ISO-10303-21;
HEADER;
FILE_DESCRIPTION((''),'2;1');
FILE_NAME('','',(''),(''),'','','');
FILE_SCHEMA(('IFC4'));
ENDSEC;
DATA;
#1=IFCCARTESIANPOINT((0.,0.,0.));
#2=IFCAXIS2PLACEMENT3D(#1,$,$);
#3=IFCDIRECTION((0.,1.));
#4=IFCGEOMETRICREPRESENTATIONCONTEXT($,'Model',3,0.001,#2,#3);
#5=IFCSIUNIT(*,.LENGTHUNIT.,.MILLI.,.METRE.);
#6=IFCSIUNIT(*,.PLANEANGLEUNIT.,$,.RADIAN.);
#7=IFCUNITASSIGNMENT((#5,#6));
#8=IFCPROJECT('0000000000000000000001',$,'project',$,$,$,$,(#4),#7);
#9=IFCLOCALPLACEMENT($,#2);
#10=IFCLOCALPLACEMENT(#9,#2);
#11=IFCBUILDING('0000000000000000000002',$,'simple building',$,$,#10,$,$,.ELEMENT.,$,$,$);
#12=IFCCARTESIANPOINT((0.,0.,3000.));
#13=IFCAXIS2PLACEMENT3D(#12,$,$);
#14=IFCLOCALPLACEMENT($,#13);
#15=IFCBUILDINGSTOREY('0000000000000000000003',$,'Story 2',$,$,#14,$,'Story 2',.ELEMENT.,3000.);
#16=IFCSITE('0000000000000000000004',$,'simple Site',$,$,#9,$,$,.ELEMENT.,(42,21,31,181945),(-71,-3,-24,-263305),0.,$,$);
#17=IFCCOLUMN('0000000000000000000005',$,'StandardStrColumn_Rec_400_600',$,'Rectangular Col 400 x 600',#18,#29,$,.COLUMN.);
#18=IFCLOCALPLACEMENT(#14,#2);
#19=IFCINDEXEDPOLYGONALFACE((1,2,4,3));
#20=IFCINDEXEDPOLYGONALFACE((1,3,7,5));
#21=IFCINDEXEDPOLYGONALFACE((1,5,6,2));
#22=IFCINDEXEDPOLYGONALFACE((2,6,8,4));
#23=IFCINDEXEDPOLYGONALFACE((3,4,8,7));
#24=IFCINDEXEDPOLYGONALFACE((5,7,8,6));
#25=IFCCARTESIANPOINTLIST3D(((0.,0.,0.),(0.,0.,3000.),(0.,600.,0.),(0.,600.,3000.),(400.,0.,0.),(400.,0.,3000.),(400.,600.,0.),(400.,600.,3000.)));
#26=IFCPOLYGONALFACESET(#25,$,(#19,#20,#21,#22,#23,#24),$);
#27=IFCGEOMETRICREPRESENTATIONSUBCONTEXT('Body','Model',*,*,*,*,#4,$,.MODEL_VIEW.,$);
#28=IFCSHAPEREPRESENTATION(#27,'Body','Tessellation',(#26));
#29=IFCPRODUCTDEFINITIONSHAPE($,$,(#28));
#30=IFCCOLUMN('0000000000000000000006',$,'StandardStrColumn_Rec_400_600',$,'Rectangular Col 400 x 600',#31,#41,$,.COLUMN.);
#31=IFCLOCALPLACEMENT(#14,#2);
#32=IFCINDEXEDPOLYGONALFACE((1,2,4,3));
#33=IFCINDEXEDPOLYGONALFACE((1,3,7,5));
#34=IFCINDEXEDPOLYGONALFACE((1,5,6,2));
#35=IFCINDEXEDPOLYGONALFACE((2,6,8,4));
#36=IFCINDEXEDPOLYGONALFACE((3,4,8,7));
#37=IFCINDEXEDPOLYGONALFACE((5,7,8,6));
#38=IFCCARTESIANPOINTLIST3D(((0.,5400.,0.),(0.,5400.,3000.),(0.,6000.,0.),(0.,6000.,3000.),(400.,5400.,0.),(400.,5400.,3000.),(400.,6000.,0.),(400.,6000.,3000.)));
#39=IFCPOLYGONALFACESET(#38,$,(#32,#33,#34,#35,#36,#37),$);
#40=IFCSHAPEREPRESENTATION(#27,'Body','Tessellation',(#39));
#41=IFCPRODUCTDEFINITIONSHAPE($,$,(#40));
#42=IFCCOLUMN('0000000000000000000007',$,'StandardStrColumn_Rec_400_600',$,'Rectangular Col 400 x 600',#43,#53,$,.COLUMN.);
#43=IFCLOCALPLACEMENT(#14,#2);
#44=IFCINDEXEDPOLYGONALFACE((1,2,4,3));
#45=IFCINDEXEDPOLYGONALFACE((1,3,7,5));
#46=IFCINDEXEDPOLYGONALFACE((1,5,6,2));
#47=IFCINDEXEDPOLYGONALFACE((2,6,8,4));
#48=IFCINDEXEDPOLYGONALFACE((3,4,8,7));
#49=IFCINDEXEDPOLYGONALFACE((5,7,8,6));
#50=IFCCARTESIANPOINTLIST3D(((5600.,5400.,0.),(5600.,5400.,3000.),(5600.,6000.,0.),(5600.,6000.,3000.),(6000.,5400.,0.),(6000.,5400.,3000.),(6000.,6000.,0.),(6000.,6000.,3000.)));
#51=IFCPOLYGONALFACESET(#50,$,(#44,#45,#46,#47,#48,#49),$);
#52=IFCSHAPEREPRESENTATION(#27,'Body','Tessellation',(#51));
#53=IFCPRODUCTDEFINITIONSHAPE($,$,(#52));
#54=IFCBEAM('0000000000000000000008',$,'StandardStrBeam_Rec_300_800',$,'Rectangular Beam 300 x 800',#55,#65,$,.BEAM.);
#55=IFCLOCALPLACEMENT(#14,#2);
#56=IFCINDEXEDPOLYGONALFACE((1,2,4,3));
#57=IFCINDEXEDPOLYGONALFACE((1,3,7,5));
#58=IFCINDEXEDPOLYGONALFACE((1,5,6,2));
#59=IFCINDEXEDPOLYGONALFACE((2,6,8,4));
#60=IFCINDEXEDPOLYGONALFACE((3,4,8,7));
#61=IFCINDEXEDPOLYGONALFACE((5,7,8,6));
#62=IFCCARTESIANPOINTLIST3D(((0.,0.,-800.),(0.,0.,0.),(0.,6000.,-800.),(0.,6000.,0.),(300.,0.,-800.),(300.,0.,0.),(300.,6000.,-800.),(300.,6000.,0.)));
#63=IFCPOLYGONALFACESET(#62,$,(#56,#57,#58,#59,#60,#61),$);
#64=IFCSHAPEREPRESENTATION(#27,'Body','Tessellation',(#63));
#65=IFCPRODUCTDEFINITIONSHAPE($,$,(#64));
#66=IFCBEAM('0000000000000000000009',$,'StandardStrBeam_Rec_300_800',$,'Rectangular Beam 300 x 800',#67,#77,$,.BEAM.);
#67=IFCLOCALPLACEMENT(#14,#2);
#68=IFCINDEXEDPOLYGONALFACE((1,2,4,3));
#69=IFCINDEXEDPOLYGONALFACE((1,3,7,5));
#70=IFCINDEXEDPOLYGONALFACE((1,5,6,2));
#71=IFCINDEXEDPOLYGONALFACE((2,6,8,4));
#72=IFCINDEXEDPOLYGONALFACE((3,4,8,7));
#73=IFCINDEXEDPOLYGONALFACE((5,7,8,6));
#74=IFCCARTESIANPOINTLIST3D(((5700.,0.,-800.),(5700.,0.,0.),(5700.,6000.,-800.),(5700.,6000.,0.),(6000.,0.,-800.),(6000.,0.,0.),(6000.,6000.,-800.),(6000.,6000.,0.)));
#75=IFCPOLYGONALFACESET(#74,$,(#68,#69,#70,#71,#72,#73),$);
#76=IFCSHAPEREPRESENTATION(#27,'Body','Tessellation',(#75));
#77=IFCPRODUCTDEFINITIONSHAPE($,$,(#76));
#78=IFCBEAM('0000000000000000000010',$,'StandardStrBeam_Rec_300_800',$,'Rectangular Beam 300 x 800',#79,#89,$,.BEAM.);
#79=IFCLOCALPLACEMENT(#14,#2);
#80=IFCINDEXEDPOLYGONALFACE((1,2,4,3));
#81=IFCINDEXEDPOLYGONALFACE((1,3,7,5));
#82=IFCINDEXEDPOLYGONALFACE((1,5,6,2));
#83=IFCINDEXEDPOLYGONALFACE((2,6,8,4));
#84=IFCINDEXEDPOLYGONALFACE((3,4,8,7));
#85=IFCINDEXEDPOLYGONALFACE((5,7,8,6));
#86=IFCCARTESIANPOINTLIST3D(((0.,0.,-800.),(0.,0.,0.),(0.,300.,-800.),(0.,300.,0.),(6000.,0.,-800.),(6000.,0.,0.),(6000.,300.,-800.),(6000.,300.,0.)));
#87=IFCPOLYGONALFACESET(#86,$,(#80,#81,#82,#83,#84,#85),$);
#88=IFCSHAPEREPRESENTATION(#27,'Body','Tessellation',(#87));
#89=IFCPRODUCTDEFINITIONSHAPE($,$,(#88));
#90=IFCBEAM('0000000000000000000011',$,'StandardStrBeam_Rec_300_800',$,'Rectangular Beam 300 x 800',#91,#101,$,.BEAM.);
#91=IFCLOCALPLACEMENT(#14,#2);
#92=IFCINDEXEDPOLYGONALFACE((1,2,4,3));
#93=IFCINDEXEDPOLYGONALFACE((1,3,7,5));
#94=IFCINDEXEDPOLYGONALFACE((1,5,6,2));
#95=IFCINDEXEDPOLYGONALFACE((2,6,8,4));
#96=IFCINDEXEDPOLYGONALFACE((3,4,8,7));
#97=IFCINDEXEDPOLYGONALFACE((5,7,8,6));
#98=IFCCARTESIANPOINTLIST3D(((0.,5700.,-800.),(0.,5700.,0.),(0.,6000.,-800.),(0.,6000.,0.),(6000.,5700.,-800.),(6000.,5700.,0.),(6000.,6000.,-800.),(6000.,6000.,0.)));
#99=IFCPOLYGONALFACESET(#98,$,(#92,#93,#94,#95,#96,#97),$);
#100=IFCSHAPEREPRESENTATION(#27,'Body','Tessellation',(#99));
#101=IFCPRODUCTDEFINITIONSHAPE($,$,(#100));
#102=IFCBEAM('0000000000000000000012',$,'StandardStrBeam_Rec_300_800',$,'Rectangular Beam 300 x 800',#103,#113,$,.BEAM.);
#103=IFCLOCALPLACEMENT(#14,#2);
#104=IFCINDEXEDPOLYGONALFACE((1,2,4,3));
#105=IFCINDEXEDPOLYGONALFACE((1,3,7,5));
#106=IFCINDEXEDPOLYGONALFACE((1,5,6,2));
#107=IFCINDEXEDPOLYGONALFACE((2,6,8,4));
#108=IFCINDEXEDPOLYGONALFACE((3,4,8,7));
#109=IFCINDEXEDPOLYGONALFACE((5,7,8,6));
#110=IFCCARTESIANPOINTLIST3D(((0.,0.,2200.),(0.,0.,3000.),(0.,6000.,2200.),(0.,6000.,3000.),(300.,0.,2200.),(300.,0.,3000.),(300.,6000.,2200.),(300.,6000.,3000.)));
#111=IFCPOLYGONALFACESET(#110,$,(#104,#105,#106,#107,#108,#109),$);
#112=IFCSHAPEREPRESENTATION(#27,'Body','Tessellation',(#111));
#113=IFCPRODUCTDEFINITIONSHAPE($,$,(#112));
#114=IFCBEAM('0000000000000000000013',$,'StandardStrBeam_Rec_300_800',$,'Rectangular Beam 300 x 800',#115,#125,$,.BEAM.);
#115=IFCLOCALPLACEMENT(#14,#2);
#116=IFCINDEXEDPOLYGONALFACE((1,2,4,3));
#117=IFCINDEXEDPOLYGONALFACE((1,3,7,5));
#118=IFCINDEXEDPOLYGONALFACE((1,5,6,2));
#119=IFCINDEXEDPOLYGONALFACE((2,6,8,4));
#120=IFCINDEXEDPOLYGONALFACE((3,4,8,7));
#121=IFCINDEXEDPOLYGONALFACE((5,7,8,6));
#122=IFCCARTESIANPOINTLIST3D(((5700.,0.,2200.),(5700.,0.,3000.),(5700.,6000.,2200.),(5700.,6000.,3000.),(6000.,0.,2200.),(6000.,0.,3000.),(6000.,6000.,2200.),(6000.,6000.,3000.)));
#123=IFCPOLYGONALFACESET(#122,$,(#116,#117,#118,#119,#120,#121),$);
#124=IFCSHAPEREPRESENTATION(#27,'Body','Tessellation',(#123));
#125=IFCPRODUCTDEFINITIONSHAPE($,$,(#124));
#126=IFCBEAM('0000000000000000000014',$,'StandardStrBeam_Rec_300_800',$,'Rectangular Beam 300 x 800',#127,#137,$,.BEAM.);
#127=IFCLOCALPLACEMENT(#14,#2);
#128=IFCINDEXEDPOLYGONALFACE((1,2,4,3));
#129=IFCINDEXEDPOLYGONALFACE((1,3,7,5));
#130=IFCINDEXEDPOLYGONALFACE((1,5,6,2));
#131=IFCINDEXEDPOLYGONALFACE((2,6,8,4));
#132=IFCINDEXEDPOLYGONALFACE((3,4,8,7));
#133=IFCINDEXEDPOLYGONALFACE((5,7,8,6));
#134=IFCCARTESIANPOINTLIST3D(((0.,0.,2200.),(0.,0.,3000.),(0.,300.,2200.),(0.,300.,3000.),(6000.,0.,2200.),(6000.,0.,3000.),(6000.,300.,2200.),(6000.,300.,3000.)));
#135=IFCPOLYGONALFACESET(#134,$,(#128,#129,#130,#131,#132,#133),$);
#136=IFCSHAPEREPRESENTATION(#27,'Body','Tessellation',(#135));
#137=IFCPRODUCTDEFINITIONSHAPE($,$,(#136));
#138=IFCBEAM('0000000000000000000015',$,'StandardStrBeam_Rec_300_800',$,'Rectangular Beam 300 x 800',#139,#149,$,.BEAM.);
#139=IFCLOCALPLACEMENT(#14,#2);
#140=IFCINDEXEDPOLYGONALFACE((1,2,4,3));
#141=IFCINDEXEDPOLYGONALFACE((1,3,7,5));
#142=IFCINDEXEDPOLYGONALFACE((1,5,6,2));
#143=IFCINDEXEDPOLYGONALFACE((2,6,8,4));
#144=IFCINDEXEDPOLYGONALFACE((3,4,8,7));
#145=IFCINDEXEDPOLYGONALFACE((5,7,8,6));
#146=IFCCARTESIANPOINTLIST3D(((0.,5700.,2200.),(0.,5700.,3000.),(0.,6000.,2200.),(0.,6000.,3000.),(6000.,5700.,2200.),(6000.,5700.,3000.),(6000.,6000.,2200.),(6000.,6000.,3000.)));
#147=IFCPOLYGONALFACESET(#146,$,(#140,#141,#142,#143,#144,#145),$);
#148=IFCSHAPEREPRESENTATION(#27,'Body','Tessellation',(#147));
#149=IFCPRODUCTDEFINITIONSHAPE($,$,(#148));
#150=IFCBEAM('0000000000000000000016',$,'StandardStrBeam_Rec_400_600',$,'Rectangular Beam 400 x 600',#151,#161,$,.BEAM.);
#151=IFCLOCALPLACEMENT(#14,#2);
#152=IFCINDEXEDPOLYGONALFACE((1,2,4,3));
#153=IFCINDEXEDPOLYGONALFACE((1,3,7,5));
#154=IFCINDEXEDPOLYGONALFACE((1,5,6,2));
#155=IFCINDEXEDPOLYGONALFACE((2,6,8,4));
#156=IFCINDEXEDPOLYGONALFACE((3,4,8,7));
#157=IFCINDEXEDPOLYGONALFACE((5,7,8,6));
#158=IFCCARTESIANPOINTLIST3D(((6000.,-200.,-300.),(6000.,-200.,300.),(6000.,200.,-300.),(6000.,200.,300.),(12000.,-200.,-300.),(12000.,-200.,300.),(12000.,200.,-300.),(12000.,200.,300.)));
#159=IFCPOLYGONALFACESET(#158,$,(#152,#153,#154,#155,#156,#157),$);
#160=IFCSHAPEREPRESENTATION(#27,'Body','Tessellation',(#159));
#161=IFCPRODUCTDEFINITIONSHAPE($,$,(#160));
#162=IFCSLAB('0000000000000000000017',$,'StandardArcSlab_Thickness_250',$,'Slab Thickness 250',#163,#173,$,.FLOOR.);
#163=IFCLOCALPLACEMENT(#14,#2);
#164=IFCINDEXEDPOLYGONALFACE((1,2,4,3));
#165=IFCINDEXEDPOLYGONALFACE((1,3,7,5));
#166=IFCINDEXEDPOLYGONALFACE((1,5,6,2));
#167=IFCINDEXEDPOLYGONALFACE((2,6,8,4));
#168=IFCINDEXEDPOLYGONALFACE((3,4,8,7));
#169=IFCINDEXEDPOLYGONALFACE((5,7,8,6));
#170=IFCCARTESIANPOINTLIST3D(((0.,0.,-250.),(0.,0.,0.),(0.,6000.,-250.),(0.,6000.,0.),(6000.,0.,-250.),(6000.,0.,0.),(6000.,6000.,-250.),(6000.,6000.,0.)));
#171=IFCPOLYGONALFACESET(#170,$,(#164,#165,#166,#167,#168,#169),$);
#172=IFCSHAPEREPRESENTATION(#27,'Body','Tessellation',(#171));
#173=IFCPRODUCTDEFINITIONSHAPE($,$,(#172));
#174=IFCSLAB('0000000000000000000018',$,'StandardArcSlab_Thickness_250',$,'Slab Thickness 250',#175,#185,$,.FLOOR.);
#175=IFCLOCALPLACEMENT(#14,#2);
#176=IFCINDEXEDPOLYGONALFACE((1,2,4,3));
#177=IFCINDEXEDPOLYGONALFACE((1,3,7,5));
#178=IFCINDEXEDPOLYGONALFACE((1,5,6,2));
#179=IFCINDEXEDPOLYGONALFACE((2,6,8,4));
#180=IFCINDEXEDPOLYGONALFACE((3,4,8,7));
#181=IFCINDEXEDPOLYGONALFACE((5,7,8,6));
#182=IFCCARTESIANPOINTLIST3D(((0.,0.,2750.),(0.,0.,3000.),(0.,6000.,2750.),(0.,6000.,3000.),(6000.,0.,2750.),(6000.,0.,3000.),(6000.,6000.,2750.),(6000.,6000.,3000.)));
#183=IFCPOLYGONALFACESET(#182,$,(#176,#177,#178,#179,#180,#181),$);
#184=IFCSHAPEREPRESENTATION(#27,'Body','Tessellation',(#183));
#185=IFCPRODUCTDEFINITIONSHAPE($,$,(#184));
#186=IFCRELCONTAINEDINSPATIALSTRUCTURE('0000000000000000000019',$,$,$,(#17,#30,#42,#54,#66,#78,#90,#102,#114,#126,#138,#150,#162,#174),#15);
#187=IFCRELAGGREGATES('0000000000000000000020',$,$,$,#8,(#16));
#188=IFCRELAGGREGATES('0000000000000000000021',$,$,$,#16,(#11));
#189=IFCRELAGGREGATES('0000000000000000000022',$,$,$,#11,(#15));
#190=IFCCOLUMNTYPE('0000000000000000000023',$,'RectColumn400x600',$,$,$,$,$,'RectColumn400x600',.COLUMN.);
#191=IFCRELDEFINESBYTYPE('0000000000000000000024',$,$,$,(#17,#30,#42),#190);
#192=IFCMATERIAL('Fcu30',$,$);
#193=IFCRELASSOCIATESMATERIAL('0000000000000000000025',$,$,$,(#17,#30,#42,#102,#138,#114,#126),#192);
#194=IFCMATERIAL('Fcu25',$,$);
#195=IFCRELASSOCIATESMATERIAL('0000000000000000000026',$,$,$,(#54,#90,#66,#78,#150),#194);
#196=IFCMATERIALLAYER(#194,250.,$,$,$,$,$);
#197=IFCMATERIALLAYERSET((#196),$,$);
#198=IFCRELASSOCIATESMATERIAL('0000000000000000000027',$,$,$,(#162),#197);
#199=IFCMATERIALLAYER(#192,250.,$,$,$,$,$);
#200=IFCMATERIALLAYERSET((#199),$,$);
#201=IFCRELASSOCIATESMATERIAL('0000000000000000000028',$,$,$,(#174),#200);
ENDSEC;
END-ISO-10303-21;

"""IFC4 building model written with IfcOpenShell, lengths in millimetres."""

from ifc_helpers import new_model, si_unit, direction, frame, origin, origin_with_axes, origin_2d_with_axis, place, context, subcontext, project, spatial, polyline, rectangle, outline, extrude, material, layer, layer_set, layer_usage, material_profile, profile_set, profile_usage, type_object, element, save


model = new_model("IFC4")

# Units and contexts
model_context = context("Model", 3, precision=0.001, world=origin(), true_north=direction((0.0, 1.0)))
body_context = subcontext(model_context, "Body", "Model", "MODEL_VIEW")
ifc_project = project(units=[si_unit("LENGTHUNIT", "METRE", prefix="MILLI"), si_unit("PLANEANGLEUNIT", "RADIAN")], contexts=[model_context])

# Site, building, storey
site_placement = place(None, origin())
site = spatial("IfcSite", under=ifc_project, at=site_placement, Name="simple Site", CompositionType="ELEMENT", RefLatitude=(42, 21, 31, 181945), RefLongitude=(-71, -3, -24, -263305), RefElevation=0.0)
building_placement = place(site_placement, origin())
building = spatial("IfcBuilding", under=site, at=building_placement, Name="simple building", CompositionType="ELEMENT")
storey_placement = place(None, frame((0.0, 0.0, 3000.0)))
storey = spatial("IfcBuildingStorey", under=building, at=storey_placement, Name="Story 2", LongName="Story 2", CompositionType="ELEMENT", Elevation=3000.0)

# Columns
ifc_material_1 = material(Name="Fcu30")
ifc_material_profile_1 = material_profile(ifc_material_1, rectangle(XDim=400.0, YDim=600.0, at=origin_2d_with_axis()))
ifc_profile_set_1 = profile_set([ifc_material_profile_1])
ifc_profile_usage_1 = profile_usage(ifc_profile_set_1, cardinal=7)
column_type = type_object("IfcColumnType", Name="RectColumn400x600", ElementType="RectColumn400x600", PredefinedType="COLUMN")
column_1_placement = place(None, frame((200.0, 300.0, 3000.0), z_axis=(0.0, 0.0, 1.0), x_axis=(1.0, 0.0, 0.0)))
element("IfcColumn", 1, at=column_1_placement, inside=storey, type_object=column_type, material=ifc_profile_usage_1, Name="StandardStrColumn_Rec_400_600", ObjectType="Rectangular Col 400 x 600", PredefinedType="COLUMN", context=body_context, shape_type="SweptSolid", body=[
    extrude(rectangle(XDim=400.0, YDim=600.0, at=origin_2d_with_axis()), origin_with_axes(), (0.0, 0.0, 1.0), 3000.0),
])
ifc_profile_usage_2 = profile_usage(ifc_profile_set_1, cardinal=1)
column_2_placement = place(None, frame((200.0, 5700.0, 3000.0), z_axis=(0.0, 0.0, 1.0), x_axis=(1.0, 0.0, 0.0)))
element("IfcColumn", 2, at=column_2_placement, inside=storey, type_object=column_type, material=ifc_profile_usage_2, Name="StandardStrColumn_Rec_400_600", ObjectType="Rectangular Col 400 x 600", PredefinedType="COLUMN", context=body_context, shape_type="SweptSolid", body=[
    extrude(rectangle(XDim=400.0, YDim=600.0, at=origin_2d_with_axis()), origin_with_axes(), (0.0, 0.0, 1.0), 3000.0),
])
ifc_profile_usage_3 = profile_usage(ifc_profile_set_1, cardinal=3)
column_3_placement = place(None, frame((5800.0, 5700.0, 3000.0), z_axis=(0.0, 0.0, 1.0), x_axis=(1.0, 0.0, 0.0)))
element("IfcColumn", 3, at=column_3_placement, inside=storey, type_object=column_type, material=ifc_profile_usage_3, Name="StandardStrColumn_Rec_400_600", ObjectType="Rectangular Col 400 x 600", PredefinedType="COLUMN", context=body_context, shape_type="SweptSolid", body=[
    extrude(rectangle(XDim=400.0, YDim=600.0, at=origin_2d_with_axis()), origin_with_axes(), (0.0, 0.0, 1.0), 3000.0),
])

# Beams
ifc_material_2 = material(Name="Fcu25")
ifc_material_profile_2 = material_profile(ifc_material_2, rectangle(XDim=300.0, YDim=800.0, at=origin_2d_with_axis()))
ifc_profile_set_2 = profile_set([ifc_material_profile_2])
ifc_profile_usage_4 = profile_usage(ifc_profile_set_2, cardinal=7)
beam_1_placement = place(None, frame((150.0, 0.0, 2600.0), z_axis=(0.0, 1.0, 0.0), x_axis=(1.0, 0.0, 0.0)))
element("IfcBeam", 4, at=beam_1_placement, inside=storey, material=ifc_profile_usage_4, Name="StandardStrBeam_Rec_300_800", ObjectType="Rectangular Beam 300 x 800", PredefinedType="BEAM", context=body_context, shape_type="SweptSolid", body=[
    extrude(rectangle(XDim=300.0, YDim=800.0, at=origin_2d_with_axis()), origin_with_axes(), (0.0, 0.0, 1.0), 6000.0),
])
ifc_profile_usage_5 = profile_usage(ifc_profile_set_2, cardinal=9)
for number, where, z_axis, x_axis, name in (
    (5, (5850.0, 0.0, 2600.0), (0.0, 1.0, 0.0), (1.0, 0.0, 0.0), "StandardStrBeam_Rec_300_800"),
    (6, (0.0, 150.0, 2600.0), (1.0, 0.0, 0.0), (0.0, -1.0, 0.0), "StandardStrBeam_Rec_300_800"),
):
    element("IfcBeam", number, at=place(None, frame(where, z_axis=z_axis, x_axis=x_axis)), inside=storey, material=ifc_profile_usage_5, Name=name, ObjectType="Rectangular Beam 300 x 800", PredefinedType="BEAM", context=body_context, shape_type="SweptSolid", body=[
        extrude(rectangle(XDim=300.0, YDim=800.0, at=origin_2d_with_axis()), origin_with_axes(), (0.0, 0.0, 1.0), 6000.0),
    ])
beam_2_placement = place(None, frame((0.0, 5850.0, 2600.0), z_axis=(1.0, 0.0, 0.0), x_axis=(0.0, -1.0, 0.0)))
element("IfcBeam", 7, at=beam_2_placement, inside=storey, material=ifc_profile_usage_4, Name="StandardStrBeam_Rec_300_800", ObjectType="Rectangular Beam 300 x 800", PredefinedType="BEAM", context=body_context, shape_type="SweptSolid", body=[
    extrude(rectangle(XDim=300.0, YDim=800.0, at=origin_2d_with_axis()), origin_with_axes(), (0.0, 0.0, 1.0), 6000.0),
])
ifc_material_profile_3 = material_profile(ifc_material_1, rectangle(XDim=300.0, YDim=800.0, at=origin_2d_with_axis()))
ifc_profile_set_3 = profile_set([ifc_material_profile_3])
ifc_profile_usage_6 = profile_usage(ifc_profile_set_3, cardinal=7)
beam_3_placement = place(None, frame((150.0, 0.0, 5600.0), z_axis=(0.0, 1.0, 0.0), x_axis=(1.0, 0.0, 0.0)))
element("IfcBeam", 8, at=beam_3_placement, inside=storey, material=ifc_profile_usage_6, Name="StandardStrBeam_Rec_300_800", ObjectType="Rectangular Beam 300 x 800", PredefinedType="BEAM", context=body_context, shape_type="SweptSolid", body=[
    extrude(rectangle(XDim=300.0, YDim=800.0, at=origin_2d_with_axis()), origin_with_axes(), (0.0, 0.0, 1.0), 6000.0),
])
ifc_profile_usage_7 = profile_usage(ifc_profile_set_3, cardinal=9)
for number, where, z_axis, x_axis, name in (
    (9, (5850.0, 0.0, 5600.0), (0.0, 1.0, 0.0), (1.0, 0.0, 0.0), "StandardStrBeam_Rec_300_800"),
    (10, (0.0, 150.0, 5600.0), (1.0, 0.0, 0.0), (0.0, -1.0, 0.0), "StandardStrBeam_Rec_300_800"),
):
    element("IfcBeam", number, at=place(None, frame(where, z_axis=z_axis, x_axis=x_axis)), inside=storey, material=ifc_profile_usage_7, Name=name, ObjectType="Rectangular Beam 300 x 800", PredefinedType="BEAM", context=body_context, shape_type="SweptSolid", body=[
        extrude(rectangle(XDim=300.0, YDim=800.0, at=origin_2d_with_axis()), origin_with_axes(), (0.0, 0.0, 1.0), 6000.0),
    ])
beam_4_placement = place(None, frame((0.0, 5850.0, 5600.0), z_axis=(1.0, 0.0, 0.0), x_axis=(0.0, -1.0, 0.0)))
element("IfcBeam", 11, at=beam_4_placement, inside=storey, material=ifc_profile_usage_6, Name="StandardStrBeam_Rec_300_800", ObjectType="Rectangular Beam 300 x 800", PredefinedType="BEAM", context=body_context, shape_type="SweptSolid", body=[
    extrude(rectangle(XDim=300.0, YDim=800.0, at=origin_2d_with_axis()), origin_with_axes(), (0.0, 0.0, 1.0), 6000.0),
])
ifc_material_profile_4 = material_profile(ifc_material_2, rectangle(XDim=400.0, YDim=600.0, at=origin_2d_with_axis()))
ifc_profile_set_4 = profile_set([ifc_material_profile_4])
ifc_profile_usage_8 = profile_usage(ifc_profile_set_4, cardinal=5)
beam_5_placement = place(None, frame((6000.0, 0.0, 3000.0), z_axis=(1.0, 0.0, 0.0), x_axis=(0.0, -1.0, 0.0)))
element("IfcBeam", 12, at=beam_5_placement, inside=storey, material=ifc_profile_usage_8, Name="StandardStrBeam_Rec_400_600", ObjectType="Rectangular Beam 400 x 600", PredefinedType="BEAM", context=body_context, shape_type="SweptSolid", body=[
    extrude(rectangle(XDim=400.0, YDim=600.0, at=origin_2d_with_axis()), origin_with_axes(), (0.0, 0.0, 1.0), 6000.0),
])

# Slabs
ifc_layer_1 = layer(ifc_material_2, 250.0)
ifc_layer_set_1 = layer_set([ifc_layer_1])
ifc_layer_usage_1 = layer_usage(ifc_layer_set_1, "AXIS3", "POSITIVE", -250.0)
slab_1_placement = place(None, frame((0.0, 0.0, 2750.0), z_axis=(0.0, 0.0, 1.0), x_axis=(1.0, 0.0, 0.0)))
element("IfcSlab", 13, at=slab_1_placement, inside=storey, material=ifc_layer_usage_1, Name="StandardArcSlab_Thickness_250", ObjectType="Slab Thickness 250", PredefinedType="FLOOR", context=body_context, shape_type="SweptSolid", body=[
    extrude(outline(polyline([(0.0, 0.0), (6000.0, 0.0), (6000.0, 6000.0), (0.0, 6000.0), (0.0, 0.0)])), origin_with_axes(), (0.0, 0.0, 1.0), 250.0),
])
ifc_layer_2 = layer(ifc_material_1, 250.0)
ifc_layer_set_2 = layer_set([ifc_layer_2])
ifc_layer_usage_2 = layer_usage(ifc_layer_set_2, "AXIS3", "POSITIVE", -250.0)
slab_2_placement = place(None, frame((0.0, 0.0, 5750.0), z_axis=(0.0, 0.0, 1.0), x_axis=(1.0, 0.0, 0.0)))
element("IfcSlab", 14, at=slab_2_placement, inside=storey, material=ifc_layer_usage_2, Name="StandardArcSlab_Thickness_250", ObjectType="Slab Thickness 250", PredefinedType="FLOOR", context=body_context, shape_type="SweptSolid", body=[
    extrude(outline(polyline([(0.0, 0.0), (6000.0, 0.0), (6000.0, 6000.0), (0.0, 6000.0), (0.0, 0.0)])), origin_with_axes(), (0.0, 0.0, 1.0), 250.0),
])

save(model, "model.ifc")
